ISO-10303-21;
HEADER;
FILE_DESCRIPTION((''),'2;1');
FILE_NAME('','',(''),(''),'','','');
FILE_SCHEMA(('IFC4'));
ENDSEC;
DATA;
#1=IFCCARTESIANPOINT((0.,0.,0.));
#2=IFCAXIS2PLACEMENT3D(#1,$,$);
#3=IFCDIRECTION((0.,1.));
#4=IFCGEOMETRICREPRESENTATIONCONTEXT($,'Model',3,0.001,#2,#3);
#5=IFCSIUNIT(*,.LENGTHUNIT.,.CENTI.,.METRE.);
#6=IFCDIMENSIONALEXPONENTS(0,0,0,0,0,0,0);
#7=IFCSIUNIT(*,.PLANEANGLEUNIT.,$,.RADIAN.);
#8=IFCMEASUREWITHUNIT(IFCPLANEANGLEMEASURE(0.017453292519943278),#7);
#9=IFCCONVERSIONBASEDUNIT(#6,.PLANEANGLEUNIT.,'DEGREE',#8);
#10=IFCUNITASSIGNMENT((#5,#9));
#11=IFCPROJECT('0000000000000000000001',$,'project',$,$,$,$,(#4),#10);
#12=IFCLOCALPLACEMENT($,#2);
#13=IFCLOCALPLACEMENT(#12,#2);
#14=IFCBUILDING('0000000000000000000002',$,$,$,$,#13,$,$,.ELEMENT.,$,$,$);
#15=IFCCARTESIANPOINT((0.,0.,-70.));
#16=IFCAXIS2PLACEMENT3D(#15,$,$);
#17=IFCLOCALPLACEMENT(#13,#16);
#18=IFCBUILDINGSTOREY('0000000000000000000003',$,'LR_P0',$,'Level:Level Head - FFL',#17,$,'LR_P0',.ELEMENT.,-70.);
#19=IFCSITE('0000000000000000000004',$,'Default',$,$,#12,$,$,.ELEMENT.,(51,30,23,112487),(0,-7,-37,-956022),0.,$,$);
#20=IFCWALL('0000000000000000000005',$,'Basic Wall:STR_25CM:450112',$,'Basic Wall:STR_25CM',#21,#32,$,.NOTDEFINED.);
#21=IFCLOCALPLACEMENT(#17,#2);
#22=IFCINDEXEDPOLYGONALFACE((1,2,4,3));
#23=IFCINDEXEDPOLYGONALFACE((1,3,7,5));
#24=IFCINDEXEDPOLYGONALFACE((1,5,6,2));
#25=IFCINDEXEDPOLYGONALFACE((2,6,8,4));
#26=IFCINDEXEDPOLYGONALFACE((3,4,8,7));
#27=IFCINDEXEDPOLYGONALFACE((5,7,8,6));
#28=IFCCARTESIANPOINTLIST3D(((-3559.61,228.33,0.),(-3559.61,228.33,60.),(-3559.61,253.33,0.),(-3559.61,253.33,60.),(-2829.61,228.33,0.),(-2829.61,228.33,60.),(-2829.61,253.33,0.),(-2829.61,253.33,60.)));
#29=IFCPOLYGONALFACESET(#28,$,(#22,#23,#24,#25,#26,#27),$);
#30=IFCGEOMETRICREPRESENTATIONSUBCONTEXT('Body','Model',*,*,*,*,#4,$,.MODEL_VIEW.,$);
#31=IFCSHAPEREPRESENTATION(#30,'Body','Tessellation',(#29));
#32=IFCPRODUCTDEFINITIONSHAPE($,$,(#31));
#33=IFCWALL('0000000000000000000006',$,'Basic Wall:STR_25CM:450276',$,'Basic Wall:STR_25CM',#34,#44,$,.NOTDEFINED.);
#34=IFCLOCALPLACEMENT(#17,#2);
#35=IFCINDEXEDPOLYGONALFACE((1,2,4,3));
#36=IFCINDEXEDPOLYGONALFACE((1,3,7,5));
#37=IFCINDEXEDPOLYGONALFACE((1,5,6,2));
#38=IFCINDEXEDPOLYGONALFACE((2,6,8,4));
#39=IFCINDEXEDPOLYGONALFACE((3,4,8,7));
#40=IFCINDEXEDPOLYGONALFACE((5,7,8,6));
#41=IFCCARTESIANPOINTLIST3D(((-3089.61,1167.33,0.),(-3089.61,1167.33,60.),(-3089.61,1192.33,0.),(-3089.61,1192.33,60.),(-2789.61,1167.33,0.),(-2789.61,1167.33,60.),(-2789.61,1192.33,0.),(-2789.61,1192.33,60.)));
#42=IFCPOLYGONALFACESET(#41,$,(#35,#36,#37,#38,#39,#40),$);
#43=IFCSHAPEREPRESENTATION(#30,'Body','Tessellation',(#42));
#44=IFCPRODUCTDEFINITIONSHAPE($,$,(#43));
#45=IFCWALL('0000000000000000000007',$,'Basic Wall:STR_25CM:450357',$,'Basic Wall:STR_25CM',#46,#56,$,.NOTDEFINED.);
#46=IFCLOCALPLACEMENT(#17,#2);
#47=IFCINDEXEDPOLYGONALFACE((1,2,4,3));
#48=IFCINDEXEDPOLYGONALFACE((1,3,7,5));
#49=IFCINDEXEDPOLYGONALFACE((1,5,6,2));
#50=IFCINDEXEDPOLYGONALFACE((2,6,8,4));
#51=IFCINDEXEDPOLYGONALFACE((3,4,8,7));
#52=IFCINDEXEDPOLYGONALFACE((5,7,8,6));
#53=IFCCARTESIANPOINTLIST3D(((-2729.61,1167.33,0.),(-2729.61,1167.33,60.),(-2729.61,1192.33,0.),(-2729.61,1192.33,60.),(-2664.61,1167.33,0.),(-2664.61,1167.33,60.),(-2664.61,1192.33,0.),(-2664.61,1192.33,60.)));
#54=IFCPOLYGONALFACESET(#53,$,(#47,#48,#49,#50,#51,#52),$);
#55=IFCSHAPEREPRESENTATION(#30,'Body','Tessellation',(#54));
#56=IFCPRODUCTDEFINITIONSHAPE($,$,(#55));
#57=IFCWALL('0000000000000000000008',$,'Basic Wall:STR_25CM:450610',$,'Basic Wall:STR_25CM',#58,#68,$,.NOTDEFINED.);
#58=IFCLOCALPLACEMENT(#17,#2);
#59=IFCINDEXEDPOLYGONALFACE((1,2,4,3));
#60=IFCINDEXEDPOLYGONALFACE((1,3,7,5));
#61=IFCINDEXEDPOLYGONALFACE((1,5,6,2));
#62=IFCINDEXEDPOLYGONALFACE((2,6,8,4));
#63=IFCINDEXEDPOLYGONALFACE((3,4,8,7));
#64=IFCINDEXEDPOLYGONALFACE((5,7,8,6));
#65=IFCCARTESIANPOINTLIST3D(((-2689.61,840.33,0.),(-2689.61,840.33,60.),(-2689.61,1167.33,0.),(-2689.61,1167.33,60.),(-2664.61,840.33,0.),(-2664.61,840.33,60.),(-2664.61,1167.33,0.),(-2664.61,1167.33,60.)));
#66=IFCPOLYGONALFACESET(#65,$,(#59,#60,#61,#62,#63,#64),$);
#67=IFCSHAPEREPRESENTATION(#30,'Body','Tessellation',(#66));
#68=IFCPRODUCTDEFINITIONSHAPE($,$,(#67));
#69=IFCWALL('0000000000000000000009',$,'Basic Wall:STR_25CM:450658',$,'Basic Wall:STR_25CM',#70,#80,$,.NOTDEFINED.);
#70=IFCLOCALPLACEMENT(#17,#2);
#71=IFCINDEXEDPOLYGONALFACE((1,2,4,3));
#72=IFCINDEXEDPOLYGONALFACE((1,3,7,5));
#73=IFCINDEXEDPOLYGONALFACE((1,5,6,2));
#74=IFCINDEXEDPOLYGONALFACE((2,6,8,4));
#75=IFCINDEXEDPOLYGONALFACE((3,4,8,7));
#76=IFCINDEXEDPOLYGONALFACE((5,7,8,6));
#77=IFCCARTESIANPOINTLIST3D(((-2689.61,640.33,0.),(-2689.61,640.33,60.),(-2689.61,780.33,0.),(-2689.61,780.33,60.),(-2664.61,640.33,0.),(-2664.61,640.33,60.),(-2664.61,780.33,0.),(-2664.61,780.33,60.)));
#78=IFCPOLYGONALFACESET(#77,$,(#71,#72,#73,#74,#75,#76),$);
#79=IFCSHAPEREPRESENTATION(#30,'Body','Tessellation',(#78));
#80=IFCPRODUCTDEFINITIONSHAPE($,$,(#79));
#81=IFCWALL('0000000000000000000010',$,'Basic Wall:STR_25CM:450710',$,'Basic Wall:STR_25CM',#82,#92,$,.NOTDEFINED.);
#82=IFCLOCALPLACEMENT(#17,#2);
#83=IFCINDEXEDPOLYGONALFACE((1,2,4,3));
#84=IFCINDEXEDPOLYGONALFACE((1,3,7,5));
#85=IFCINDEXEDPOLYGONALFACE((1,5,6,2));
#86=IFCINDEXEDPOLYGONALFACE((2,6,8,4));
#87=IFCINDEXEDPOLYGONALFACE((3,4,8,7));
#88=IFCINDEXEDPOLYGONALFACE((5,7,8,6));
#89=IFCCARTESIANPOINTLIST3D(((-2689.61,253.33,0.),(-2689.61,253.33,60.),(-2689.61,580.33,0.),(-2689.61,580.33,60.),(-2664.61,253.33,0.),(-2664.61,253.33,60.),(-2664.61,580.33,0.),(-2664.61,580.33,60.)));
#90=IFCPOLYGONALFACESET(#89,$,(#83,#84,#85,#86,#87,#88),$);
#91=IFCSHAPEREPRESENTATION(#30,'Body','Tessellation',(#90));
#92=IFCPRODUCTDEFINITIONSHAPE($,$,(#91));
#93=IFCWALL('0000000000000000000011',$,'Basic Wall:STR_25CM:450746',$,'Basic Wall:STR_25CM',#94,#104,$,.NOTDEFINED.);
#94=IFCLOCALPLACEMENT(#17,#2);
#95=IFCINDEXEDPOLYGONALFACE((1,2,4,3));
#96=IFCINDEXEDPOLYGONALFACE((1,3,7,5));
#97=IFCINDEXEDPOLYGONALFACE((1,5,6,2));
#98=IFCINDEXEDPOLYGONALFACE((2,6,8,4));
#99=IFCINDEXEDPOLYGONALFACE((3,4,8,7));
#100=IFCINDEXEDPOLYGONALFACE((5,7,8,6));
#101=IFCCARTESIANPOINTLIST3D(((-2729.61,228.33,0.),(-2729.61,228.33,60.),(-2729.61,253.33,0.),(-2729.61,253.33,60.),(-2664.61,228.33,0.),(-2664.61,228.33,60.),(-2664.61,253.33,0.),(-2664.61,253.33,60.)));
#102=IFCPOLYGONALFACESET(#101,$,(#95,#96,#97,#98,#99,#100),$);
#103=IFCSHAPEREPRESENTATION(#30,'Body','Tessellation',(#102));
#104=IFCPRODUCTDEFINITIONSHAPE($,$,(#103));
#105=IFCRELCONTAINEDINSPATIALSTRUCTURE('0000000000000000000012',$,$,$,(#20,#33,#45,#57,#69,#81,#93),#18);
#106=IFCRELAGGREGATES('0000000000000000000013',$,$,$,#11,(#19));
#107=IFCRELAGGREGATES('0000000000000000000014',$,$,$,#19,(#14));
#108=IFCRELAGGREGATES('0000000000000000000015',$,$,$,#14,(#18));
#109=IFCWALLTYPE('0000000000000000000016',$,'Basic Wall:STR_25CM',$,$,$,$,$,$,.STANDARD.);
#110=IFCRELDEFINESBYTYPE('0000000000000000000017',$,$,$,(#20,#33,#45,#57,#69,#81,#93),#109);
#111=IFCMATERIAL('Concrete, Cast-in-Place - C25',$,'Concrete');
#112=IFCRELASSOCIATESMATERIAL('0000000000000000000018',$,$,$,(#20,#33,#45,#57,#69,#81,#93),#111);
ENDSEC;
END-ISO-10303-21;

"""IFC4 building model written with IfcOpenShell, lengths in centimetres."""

from ifc_helpers import new_model, entity, si_unit, converted_unit, direction, frame, origin, place, context, subcontext, project, spatial, indexed_curve, outline, extrude, material, type_object, element, save


model = new_model("IFC4")

# Units and contexts
model_context = context("Model", 3, precision=0.001, world=origin(), true_north=direction((0.0, 1.0)))
body_context = subcontext(model_context, "Body", "Model", "MODEL_VIEW")
ifc_project = project(units=[si_unit("LENGTHUNIT", "METRE", prefix="CENTI"), converted_unit("PLANEANGLEUNIT", "DEGREE", entity("IfcPlaneAngleMeasure", 0.017453292519943278), si_unit("PLANEANGLEUNIT", "RADIAN"), dimensions=[0, 0, 0, 0, 0, 0, 0])], contexts=[model_context])

# Site, building, storey
site_placement = place(None, origin())
site = spatial("IfcSite", under=ifc_project, at=site_placement, Name="Default", CompositionType="ELEMENT", RefLatitude=(51, 30, 23, 112487), RefLongitude=(0, -7, -37, -956022), RefElevation=0.0)
building_placement = place(site_placement, origin())
building = spatial("IfcBuilding", under=site, at=building_placement, CompositionType="ELEMENT")
storey_placement = place(building_placement, frame((0.0, 0.0, -70.0)))
storey = spatial("IfcBuildingStorey", under=building, at=storey_placement, Name="LR_P0", ObjectType="Level:Level Head - FFL", LongName="LR_P0", CompositionType="ELEMENT", Elevation=-70.0)

# Walls
ifc_material_1 = material(Name="Concrete, Cast-in-Place - C25", Category="Concrete")
wall_type = type_object("IfcWallType", Name="Basic Wall:STR_25CM", PredefinedType="STANDARD")
wall_1_placement = place(storey_placement, frame((-3559.61, 240.83, 0.0)))
element("IfcWall", 1, at=wall_1_placement, inside=storey, type_object=wall_type, material=ifc_material_1, Name="Basic Wall:STR_25CM:450112", ObjectType="Basic Wall:STR_25CM", PredefinedType="NOTDEFINED", context=body_context, shape_type="SweptSolid", body=[
    extrude(outline(indexed_curve([(730.0, 12.5), (0.0, 12.5), (0.0, -12.5), (730.0, -12.5), (730.0, 12.5)], self_intersect=False)), origin(), (0.0, 0.0, 1.0), 60.0),
])
wall_2_placement = place(storey_placement, frame((-3089.61, 1179.83, 0.0)))
element("IfcWall", 2, at=wall_2_placement, inside=storey, type_object=wall_type, material=ifc_material_1, Name="Basic Wall:STR_25CM:450276", ObjectType="Basic Wall:STR_25CM", PredefinedType="NOTDEFINED", context=body_context, shape_type="SweptSolid", body=[
    extrude(outline(indexed_curve([(300.0, 12.5), (0.0, 12.5), (0.0, -12.5), (300.0, -12.5), (300.0, 12.5)], self_intersect=False)), origin(), (0.0, 0.0, 1.0), 60.0),
])
wall_3_placement = place(storey_placement, frame((-2729.61, 1179.83, 0.0)))
element("IfcWall", 3, at=wall_3_placement, inside=storey, type_object=wall_type, material=ifc_material_1, Name="Basic Wall:STR_25CM:450357", ObjectType="Basic Wall:STR_25CM", PredefinedType="NOTDEFINED", context=body_context, shape_type="SweptSolid", body=[
    extrude(outline(indexed_curve([(65.0, 12.5), (0.0, 12.5), (0.0, -12.5), (65.0, -12.5), (65.0, 12.5)], self_intersect=False)), origin(), (0.0, 0.0, 1.0), 60.0),
])
wall_4_placement = place(storey_placement, frame((-2677.11, 1167.33, 0.0), z_axis=(0.0, 0.0, 1.0), x_axis=(0.0, -1.0, 0.0)))
element("IfcWall", 4, at=wall_4_placement, inside=storey, type_object=wall_type, material=ifc_material_1, Name="Basic Wall:STR_25CM:450610", ObjectType="Basic Wall:STR_25CM", PredefinedType="NOTDEFINED", context=body_context, shape_type="SweptSolid", body=[
    extrude(outline(indexed_curve([(327.0, 12.5), (0.0, 12.5), (0.0, -12.5), (327.0, -12.5), (327.0, 12.5)], self_intersect=False)), origin(), (0.0, 0.0, 1.0), 60.0),
])
wall_5_placement = place(storey_placement, frame((-2677.11, 780.33, 0.0), z_axis=(0.0, 0.0, 1.0), x_axis=(0.0, -1.0, 0.0)))
element("IfcWall", 5, at=wall_5_placement, inside=storey, type_object=wall_type, material=ifc_material_1, Name="Basic Wall:STR_25CM:450658", ObjectType="Basic Wall:STR_25CM", PredefinedType="NOTDEFINED", context=body_context, shape_type="SweptSolid", body=[
    extrude(outline(indexed_curve([(140.0, 12.5), (0.0, 12.5), (0.0, -12.5), (140.0, -12.5), (140.0, 12.5)], self_intersect=False)), origin(), (0.0, 0.0, 1.0), 60.0),
])
wall_6_placement = place(storey_placement, frame((-2677.11, 580.33, 0.0), z_axis=(0.0, 0.0, 1.0), x_axis=(0.0, -1.0, 0.0)))
element("IfcWall", 6, at=wall_6_placement, inside=storey, type_object=wall_type, material=ifc_material_1, Name="Basic Wall:STR_25CM:450710", ObjectType="Basic Wall:STR_25CM", PredefinedType="NOTDEFINED", context=body_context, shape_type="SweptSolid", body=[
    extrude(outline(indexed_curve([(327.0, 12.5), (0.0, 12.5), (0.0, -12.5), (327.0, -12.5), (327.0, 12.5)], self_intersect=False)), origin(), (0.0, 0.0, 1.0), 60.0),
])
wall_7_placement = place(storey_placement, frame((-2664.61, 240.83, 0.0), z_axis=(0.0, 0.0, 1.0), x_axis=(-1.0, 0.0, 0.0)))
element("IfcWall", 7, at=wall_7_placement, inside=storey, type_object=wall_type, material=ifc_material_1, Name="Basic Wall:STR_25CM:450746", ObjectType="Basic Wall:STR_25CM", PredefinedType="NOTDEFINED", context=body_context, shape_type="SweptSolid", body=[
    extrude(outline(indexed_curve([(65.0, 12.5), (0.0, 12.5), (0.0, -12.5), (65.0, -12.5), (65.0, 12.5)], self_intersect=False)), origin(), (0.0, 0.0, 1.0), 60.0),
])

save(model, "model.ifc")
